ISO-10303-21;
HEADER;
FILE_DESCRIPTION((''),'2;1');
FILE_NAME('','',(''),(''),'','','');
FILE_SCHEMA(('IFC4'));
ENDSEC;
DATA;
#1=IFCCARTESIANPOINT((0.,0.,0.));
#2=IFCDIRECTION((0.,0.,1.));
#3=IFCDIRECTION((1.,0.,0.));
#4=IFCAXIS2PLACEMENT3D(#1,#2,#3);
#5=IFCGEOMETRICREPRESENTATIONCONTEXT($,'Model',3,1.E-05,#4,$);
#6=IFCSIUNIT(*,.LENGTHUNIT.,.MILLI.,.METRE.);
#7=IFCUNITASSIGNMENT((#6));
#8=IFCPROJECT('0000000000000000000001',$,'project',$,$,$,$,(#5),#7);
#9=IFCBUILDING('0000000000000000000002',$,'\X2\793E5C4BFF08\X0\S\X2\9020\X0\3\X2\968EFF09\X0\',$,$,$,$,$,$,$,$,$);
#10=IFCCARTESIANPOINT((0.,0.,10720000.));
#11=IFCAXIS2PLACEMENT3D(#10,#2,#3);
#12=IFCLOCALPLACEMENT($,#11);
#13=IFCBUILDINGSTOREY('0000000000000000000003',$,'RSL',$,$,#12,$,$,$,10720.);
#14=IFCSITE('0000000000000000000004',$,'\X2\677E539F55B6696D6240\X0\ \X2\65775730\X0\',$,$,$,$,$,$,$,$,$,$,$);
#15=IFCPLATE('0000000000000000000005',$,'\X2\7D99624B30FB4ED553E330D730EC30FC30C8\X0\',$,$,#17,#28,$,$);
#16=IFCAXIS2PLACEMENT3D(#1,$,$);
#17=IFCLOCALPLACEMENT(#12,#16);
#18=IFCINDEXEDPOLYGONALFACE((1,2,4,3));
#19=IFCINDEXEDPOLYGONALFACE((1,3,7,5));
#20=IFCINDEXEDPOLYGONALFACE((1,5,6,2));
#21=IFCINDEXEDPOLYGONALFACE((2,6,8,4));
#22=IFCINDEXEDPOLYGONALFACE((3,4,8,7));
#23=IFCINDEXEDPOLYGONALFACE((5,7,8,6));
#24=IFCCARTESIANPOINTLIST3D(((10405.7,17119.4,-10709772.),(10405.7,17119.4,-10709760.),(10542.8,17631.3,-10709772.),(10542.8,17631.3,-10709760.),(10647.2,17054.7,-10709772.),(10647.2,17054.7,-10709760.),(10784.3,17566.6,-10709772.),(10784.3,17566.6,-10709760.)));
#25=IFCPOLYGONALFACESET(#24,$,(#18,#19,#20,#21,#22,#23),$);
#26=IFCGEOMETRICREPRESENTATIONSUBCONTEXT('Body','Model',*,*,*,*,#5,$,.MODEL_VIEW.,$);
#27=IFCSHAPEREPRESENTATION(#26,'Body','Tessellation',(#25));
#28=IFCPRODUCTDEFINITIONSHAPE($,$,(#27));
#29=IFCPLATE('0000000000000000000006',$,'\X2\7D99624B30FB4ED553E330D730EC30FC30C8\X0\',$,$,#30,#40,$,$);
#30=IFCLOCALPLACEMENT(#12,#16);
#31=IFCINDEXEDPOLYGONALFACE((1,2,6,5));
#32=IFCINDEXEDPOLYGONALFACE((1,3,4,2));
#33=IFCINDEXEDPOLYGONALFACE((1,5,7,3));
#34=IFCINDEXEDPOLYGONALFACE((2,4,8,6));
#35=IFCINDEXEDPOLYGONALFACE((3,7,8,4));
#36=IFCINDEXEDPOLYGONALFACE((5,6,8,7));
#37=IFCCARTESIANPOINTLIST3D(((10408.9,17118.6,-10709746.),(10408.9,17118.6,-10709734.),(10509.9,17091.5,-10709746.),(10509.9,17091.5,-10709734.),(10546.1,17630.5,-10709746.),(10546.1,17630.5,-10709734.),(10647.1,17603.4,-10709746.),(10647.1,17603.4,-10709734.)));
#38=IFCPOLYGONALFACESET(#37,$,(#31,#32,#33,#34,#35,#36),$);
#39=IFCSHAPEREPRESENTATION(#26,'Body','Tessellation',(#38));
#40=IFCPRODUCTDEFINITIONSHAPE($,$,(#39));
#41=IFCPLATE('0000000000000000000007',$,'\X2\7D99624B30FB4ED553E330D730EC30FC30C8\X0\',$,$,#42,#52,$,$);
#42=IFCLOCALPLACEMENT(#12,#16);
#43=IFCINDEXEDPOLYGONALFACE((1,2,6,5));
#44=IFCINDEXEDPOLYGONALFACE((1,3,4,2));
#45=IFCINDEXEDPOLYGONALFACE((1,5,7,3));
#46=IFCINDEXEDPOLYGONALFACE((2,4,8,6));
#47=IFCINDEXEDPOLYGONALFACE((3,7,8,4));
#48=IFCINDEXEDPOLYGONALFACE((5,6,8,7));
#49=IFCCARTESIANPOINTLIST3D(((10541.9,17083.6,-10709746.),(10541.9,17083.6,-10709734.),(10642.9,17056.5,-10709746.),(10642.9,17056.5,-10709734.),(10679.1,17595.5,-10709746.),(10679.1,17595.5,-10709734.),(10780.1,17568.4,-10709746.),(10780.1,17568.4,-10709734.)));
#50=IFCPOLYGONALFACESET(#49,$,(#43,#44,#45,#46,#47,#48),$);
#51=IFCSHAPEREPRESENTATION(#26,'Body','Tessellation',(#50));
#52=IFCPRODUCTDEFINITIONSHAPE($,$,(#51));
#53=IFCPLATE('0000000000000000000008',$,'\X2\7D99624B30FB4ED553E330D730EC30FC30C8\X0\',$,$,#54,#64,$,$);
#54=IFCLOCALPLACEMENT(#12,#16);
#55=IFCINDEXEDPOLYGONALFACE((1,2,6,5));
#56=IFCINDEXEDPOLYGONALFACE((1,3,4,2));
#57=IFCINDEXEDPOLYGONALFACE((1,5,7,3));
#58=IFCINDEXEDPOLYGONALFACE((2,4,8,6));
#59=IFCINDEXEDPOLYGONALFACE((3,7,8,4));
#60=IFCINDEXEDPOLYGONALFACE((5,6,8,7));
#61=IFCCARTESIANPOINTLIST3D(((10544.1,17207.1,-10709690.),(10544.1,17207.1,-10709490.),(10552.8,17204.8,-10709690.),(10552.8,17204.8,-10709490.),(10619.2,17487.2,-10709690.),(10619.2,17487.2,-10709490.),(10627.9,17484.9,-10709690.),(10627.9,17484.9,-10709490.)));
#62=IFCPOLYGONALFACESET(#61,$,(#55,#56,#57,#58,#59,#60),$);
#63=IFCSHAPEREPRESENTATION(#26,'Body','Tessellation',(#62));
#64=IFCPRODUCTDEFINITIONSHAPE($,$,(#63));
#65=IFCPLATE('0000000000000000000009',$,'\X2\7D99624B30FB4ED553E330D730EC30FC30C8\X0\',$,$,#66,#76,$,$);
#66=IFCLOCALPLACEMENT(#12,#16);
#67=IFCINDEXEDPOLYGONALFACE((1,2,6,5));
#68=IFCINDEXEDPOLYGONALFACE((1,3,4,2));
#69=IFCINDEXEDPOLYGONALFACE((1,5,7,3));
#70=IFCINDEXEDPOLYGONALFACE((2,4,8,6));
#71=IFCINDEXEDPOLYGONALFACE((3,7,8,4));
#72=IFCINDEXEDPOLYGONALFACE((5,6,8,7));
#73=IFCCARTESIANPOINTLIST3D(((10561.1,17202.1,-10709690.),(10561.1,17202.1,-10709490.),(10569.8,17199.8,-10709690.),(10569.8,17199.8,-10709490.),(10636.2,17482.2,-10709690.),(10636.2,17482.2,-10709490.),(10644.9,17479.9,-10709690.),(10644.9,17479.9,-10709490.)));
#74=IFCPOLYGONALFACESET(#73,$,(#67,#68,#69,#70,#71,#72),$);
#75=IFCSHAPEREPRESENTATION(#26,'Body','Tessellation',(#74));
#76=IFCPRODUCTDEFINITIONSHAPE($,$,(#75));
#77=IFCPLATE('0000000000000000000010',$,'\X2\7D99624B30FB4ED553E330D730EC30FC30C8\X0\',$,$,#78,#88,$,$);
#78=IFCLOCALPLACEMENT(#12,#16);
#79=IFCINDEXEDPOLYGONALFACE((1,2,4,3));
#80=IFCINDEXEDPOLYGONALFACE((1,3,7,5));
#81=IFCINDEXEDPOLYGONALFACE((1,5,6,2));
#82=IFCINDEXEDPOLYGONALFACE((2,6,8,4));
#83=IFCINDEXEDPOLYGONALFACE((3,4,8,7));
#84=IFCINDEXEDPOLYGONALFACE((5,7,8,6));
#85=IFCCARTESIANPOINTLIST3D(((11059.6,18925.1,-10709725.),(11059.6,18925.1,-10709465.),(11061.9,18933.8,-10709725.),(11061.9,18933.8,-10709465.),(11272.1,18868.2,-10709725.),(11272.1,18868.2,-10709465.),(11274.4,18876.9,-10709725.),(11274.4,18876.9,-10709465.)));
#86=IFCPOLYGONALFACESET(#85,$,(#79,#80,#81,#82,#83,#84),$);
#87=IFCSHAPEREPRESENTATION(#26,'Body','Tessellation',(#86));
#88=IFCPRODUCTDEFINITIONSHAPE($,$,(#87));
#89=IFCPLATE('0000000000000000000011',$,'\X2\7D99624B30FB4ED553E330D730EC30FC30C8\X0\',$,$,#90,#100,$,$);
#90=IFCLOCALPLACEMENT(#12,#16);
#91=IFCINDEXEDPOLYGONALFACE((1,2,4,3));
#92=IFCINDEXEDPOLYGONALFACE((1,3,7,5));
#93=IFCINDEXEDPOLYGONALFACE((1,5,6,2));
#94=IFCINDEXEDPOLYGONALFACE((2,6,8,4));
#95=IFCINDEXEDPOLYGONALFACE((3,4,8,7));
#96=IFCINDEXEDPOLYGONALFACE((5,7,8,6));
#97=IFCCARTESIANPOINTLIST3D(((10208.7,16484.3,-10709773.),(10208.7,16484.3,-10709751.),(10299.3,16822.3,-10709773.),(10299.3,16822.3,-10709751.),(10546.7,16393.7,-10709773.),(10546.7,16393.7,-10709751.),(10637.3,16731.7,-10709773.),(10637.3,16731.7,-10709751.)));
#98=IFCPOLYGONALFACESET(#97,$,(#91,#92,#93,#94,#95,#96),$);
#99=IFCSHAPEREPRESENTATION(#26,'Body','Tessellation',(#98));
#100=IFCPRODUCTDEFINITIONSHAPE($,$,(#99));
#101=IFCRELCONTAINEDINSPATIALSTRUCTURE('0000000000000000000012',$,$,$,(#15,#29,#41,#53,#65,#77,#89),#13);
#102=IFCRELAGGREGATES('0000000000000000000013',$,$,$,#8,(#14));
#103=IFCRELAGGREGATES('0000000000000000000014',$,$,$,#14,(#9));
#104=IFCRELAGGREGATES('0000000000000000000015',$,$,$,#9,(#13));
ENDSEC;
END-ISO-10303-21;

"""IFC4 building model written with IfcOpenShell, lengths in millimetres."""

from ifc_helpers import new_model, si_unit, frame, origin, origin_with_axes, place, context, subcontext, project, spatial, rectangle, extrude, element, save


model = new_model("IFC4")

# Units and contexts
model_context = context("Model", 3, precision=1e-05, world=origin_with_axes())
body_context = subcontext(model_context, "Body", "Model", "MODEL_VIEW")
ifc_project = project(units=[si_unit("LENGTHUNIT", "METRE", prefix="MILLI")], contexts=[model_context])

# Site, building, storey
site = spatial("IfcSite", under=ifc_project, Name="松原営業所 敷地")
building = spatial("IfcBuilding", under=site, Name="社屋（S造3階）")
storey_placement = place(None, frame((0.0, 0.0, 10720000.0), z_axis=(0.0, 0.0, 1.0), x_axis=(1.0, 0.0, 0.0)))
storey = spatial("IfcBuildingStorey", under=building, at=storey_placement, Name="RSL", Elevation=10720.0)

# Plates
plate_1_placement = place(storey_placement, frame((10526.4, 17087.0, -10709766.0), z_axis=(0.258819, 0.965926, 0.0), x_axis=(-0.965926, 0.258819, 0.0)))
element("IfcPlate", 1, at=plate_1_placement, inside=storey, Name="継手・仕口プレート", context=body_context, shape_type="SweptSolid", body=[
    extrude(rectangle(XDim=250.0, YDim=12.0), origin(), (0.0, 0.0, 1.0), 530.0),
])
for number, where, z_axis, x_axis, name in (
    (2, (10459.4, 17105.0, -10709740.0), (0.258819, 0.965926, 0.0), (-0.965926, 0.258819, 0.0), "継手・仕口プレート"),
    (3, (10592.4, 17070.0, -10709740.0), (0.258819, 0.965926, 0.0), (-0.965926, 0.258819, 0.0), "継手・仕口プレート"),
):
    element("IfcPlate", number, at=place(storey_placement, frame(where, z_axis=z_axis, x_axis=x_axis)), inside=storey, Name=name, context=body_context, shape_type="SweptSolid", body=[
        extrude(rectangle(XDim=104.5, YDim=12.0), origin(), (0.0, 0.0, 1.0), 530.0),
    ])
for number, where, z_axis, x_axis, name in (
    (4, (10548.5, 17205.9, -10709590.0), (0.258819, 0.965926, 0.0), (-0.965926, 0.258819, 0.0), "継手・仕口プレート"),
    (5, (10565.5, 17200.9, -10709590.0), (0.258819, 0.965926, 0.0), (-0.965926, 0.258819, 0.0), "継手・仕口プレート"),
):
    element("IfcPlate", number, at=place(storey_placement, frame(where, z_axis=z_axis, x_axis=x_axis)), inside=storey, Name=name, context=body_context, shape_type="SweptSolid", body=[
        extrude(rectangle(XDim=9.0, YDim=200.0), origin(), (0.0, 0.0, 1.0), 290.0),
    ])
plate_2_placement = place(storey_placement, frame((11060.7, 18929.5, -10709595.0), z_axis=(0.965926, -0.258819, 0.0), x_axis=(0.258819, 0.965926, 0.0)))
element("IfcPlate", 6, at=plate_2_placement, inside=storey, Name="継手・仕口プレート", context=body_context, shape_type="SweptSolid", body=[
    extrude(rectangle(XDim=9.0, YDim=260.0), origin(), (0.0, 0.0, 1.0), 220.0),
])
plate_3_placement = place(storey_placement, frame((10254.0, 16653.3, -10709762.0), z_axis=(0.965926, -0.258819, 0.0), x_axis=(0.258819, 0.965926, 0.0)))
element("IfcPlate", 7, at=plate_3_placement, inside=storey, Name="継手・仕口プレート", context=body_context, shape_type="SweptSolid", body=[
    extrude(rectangle(XDim=350.0, YDim=22.0), origin(), (0.0, 0.0, 1.0), 350.0),
])

save(model, "model.ifc")
